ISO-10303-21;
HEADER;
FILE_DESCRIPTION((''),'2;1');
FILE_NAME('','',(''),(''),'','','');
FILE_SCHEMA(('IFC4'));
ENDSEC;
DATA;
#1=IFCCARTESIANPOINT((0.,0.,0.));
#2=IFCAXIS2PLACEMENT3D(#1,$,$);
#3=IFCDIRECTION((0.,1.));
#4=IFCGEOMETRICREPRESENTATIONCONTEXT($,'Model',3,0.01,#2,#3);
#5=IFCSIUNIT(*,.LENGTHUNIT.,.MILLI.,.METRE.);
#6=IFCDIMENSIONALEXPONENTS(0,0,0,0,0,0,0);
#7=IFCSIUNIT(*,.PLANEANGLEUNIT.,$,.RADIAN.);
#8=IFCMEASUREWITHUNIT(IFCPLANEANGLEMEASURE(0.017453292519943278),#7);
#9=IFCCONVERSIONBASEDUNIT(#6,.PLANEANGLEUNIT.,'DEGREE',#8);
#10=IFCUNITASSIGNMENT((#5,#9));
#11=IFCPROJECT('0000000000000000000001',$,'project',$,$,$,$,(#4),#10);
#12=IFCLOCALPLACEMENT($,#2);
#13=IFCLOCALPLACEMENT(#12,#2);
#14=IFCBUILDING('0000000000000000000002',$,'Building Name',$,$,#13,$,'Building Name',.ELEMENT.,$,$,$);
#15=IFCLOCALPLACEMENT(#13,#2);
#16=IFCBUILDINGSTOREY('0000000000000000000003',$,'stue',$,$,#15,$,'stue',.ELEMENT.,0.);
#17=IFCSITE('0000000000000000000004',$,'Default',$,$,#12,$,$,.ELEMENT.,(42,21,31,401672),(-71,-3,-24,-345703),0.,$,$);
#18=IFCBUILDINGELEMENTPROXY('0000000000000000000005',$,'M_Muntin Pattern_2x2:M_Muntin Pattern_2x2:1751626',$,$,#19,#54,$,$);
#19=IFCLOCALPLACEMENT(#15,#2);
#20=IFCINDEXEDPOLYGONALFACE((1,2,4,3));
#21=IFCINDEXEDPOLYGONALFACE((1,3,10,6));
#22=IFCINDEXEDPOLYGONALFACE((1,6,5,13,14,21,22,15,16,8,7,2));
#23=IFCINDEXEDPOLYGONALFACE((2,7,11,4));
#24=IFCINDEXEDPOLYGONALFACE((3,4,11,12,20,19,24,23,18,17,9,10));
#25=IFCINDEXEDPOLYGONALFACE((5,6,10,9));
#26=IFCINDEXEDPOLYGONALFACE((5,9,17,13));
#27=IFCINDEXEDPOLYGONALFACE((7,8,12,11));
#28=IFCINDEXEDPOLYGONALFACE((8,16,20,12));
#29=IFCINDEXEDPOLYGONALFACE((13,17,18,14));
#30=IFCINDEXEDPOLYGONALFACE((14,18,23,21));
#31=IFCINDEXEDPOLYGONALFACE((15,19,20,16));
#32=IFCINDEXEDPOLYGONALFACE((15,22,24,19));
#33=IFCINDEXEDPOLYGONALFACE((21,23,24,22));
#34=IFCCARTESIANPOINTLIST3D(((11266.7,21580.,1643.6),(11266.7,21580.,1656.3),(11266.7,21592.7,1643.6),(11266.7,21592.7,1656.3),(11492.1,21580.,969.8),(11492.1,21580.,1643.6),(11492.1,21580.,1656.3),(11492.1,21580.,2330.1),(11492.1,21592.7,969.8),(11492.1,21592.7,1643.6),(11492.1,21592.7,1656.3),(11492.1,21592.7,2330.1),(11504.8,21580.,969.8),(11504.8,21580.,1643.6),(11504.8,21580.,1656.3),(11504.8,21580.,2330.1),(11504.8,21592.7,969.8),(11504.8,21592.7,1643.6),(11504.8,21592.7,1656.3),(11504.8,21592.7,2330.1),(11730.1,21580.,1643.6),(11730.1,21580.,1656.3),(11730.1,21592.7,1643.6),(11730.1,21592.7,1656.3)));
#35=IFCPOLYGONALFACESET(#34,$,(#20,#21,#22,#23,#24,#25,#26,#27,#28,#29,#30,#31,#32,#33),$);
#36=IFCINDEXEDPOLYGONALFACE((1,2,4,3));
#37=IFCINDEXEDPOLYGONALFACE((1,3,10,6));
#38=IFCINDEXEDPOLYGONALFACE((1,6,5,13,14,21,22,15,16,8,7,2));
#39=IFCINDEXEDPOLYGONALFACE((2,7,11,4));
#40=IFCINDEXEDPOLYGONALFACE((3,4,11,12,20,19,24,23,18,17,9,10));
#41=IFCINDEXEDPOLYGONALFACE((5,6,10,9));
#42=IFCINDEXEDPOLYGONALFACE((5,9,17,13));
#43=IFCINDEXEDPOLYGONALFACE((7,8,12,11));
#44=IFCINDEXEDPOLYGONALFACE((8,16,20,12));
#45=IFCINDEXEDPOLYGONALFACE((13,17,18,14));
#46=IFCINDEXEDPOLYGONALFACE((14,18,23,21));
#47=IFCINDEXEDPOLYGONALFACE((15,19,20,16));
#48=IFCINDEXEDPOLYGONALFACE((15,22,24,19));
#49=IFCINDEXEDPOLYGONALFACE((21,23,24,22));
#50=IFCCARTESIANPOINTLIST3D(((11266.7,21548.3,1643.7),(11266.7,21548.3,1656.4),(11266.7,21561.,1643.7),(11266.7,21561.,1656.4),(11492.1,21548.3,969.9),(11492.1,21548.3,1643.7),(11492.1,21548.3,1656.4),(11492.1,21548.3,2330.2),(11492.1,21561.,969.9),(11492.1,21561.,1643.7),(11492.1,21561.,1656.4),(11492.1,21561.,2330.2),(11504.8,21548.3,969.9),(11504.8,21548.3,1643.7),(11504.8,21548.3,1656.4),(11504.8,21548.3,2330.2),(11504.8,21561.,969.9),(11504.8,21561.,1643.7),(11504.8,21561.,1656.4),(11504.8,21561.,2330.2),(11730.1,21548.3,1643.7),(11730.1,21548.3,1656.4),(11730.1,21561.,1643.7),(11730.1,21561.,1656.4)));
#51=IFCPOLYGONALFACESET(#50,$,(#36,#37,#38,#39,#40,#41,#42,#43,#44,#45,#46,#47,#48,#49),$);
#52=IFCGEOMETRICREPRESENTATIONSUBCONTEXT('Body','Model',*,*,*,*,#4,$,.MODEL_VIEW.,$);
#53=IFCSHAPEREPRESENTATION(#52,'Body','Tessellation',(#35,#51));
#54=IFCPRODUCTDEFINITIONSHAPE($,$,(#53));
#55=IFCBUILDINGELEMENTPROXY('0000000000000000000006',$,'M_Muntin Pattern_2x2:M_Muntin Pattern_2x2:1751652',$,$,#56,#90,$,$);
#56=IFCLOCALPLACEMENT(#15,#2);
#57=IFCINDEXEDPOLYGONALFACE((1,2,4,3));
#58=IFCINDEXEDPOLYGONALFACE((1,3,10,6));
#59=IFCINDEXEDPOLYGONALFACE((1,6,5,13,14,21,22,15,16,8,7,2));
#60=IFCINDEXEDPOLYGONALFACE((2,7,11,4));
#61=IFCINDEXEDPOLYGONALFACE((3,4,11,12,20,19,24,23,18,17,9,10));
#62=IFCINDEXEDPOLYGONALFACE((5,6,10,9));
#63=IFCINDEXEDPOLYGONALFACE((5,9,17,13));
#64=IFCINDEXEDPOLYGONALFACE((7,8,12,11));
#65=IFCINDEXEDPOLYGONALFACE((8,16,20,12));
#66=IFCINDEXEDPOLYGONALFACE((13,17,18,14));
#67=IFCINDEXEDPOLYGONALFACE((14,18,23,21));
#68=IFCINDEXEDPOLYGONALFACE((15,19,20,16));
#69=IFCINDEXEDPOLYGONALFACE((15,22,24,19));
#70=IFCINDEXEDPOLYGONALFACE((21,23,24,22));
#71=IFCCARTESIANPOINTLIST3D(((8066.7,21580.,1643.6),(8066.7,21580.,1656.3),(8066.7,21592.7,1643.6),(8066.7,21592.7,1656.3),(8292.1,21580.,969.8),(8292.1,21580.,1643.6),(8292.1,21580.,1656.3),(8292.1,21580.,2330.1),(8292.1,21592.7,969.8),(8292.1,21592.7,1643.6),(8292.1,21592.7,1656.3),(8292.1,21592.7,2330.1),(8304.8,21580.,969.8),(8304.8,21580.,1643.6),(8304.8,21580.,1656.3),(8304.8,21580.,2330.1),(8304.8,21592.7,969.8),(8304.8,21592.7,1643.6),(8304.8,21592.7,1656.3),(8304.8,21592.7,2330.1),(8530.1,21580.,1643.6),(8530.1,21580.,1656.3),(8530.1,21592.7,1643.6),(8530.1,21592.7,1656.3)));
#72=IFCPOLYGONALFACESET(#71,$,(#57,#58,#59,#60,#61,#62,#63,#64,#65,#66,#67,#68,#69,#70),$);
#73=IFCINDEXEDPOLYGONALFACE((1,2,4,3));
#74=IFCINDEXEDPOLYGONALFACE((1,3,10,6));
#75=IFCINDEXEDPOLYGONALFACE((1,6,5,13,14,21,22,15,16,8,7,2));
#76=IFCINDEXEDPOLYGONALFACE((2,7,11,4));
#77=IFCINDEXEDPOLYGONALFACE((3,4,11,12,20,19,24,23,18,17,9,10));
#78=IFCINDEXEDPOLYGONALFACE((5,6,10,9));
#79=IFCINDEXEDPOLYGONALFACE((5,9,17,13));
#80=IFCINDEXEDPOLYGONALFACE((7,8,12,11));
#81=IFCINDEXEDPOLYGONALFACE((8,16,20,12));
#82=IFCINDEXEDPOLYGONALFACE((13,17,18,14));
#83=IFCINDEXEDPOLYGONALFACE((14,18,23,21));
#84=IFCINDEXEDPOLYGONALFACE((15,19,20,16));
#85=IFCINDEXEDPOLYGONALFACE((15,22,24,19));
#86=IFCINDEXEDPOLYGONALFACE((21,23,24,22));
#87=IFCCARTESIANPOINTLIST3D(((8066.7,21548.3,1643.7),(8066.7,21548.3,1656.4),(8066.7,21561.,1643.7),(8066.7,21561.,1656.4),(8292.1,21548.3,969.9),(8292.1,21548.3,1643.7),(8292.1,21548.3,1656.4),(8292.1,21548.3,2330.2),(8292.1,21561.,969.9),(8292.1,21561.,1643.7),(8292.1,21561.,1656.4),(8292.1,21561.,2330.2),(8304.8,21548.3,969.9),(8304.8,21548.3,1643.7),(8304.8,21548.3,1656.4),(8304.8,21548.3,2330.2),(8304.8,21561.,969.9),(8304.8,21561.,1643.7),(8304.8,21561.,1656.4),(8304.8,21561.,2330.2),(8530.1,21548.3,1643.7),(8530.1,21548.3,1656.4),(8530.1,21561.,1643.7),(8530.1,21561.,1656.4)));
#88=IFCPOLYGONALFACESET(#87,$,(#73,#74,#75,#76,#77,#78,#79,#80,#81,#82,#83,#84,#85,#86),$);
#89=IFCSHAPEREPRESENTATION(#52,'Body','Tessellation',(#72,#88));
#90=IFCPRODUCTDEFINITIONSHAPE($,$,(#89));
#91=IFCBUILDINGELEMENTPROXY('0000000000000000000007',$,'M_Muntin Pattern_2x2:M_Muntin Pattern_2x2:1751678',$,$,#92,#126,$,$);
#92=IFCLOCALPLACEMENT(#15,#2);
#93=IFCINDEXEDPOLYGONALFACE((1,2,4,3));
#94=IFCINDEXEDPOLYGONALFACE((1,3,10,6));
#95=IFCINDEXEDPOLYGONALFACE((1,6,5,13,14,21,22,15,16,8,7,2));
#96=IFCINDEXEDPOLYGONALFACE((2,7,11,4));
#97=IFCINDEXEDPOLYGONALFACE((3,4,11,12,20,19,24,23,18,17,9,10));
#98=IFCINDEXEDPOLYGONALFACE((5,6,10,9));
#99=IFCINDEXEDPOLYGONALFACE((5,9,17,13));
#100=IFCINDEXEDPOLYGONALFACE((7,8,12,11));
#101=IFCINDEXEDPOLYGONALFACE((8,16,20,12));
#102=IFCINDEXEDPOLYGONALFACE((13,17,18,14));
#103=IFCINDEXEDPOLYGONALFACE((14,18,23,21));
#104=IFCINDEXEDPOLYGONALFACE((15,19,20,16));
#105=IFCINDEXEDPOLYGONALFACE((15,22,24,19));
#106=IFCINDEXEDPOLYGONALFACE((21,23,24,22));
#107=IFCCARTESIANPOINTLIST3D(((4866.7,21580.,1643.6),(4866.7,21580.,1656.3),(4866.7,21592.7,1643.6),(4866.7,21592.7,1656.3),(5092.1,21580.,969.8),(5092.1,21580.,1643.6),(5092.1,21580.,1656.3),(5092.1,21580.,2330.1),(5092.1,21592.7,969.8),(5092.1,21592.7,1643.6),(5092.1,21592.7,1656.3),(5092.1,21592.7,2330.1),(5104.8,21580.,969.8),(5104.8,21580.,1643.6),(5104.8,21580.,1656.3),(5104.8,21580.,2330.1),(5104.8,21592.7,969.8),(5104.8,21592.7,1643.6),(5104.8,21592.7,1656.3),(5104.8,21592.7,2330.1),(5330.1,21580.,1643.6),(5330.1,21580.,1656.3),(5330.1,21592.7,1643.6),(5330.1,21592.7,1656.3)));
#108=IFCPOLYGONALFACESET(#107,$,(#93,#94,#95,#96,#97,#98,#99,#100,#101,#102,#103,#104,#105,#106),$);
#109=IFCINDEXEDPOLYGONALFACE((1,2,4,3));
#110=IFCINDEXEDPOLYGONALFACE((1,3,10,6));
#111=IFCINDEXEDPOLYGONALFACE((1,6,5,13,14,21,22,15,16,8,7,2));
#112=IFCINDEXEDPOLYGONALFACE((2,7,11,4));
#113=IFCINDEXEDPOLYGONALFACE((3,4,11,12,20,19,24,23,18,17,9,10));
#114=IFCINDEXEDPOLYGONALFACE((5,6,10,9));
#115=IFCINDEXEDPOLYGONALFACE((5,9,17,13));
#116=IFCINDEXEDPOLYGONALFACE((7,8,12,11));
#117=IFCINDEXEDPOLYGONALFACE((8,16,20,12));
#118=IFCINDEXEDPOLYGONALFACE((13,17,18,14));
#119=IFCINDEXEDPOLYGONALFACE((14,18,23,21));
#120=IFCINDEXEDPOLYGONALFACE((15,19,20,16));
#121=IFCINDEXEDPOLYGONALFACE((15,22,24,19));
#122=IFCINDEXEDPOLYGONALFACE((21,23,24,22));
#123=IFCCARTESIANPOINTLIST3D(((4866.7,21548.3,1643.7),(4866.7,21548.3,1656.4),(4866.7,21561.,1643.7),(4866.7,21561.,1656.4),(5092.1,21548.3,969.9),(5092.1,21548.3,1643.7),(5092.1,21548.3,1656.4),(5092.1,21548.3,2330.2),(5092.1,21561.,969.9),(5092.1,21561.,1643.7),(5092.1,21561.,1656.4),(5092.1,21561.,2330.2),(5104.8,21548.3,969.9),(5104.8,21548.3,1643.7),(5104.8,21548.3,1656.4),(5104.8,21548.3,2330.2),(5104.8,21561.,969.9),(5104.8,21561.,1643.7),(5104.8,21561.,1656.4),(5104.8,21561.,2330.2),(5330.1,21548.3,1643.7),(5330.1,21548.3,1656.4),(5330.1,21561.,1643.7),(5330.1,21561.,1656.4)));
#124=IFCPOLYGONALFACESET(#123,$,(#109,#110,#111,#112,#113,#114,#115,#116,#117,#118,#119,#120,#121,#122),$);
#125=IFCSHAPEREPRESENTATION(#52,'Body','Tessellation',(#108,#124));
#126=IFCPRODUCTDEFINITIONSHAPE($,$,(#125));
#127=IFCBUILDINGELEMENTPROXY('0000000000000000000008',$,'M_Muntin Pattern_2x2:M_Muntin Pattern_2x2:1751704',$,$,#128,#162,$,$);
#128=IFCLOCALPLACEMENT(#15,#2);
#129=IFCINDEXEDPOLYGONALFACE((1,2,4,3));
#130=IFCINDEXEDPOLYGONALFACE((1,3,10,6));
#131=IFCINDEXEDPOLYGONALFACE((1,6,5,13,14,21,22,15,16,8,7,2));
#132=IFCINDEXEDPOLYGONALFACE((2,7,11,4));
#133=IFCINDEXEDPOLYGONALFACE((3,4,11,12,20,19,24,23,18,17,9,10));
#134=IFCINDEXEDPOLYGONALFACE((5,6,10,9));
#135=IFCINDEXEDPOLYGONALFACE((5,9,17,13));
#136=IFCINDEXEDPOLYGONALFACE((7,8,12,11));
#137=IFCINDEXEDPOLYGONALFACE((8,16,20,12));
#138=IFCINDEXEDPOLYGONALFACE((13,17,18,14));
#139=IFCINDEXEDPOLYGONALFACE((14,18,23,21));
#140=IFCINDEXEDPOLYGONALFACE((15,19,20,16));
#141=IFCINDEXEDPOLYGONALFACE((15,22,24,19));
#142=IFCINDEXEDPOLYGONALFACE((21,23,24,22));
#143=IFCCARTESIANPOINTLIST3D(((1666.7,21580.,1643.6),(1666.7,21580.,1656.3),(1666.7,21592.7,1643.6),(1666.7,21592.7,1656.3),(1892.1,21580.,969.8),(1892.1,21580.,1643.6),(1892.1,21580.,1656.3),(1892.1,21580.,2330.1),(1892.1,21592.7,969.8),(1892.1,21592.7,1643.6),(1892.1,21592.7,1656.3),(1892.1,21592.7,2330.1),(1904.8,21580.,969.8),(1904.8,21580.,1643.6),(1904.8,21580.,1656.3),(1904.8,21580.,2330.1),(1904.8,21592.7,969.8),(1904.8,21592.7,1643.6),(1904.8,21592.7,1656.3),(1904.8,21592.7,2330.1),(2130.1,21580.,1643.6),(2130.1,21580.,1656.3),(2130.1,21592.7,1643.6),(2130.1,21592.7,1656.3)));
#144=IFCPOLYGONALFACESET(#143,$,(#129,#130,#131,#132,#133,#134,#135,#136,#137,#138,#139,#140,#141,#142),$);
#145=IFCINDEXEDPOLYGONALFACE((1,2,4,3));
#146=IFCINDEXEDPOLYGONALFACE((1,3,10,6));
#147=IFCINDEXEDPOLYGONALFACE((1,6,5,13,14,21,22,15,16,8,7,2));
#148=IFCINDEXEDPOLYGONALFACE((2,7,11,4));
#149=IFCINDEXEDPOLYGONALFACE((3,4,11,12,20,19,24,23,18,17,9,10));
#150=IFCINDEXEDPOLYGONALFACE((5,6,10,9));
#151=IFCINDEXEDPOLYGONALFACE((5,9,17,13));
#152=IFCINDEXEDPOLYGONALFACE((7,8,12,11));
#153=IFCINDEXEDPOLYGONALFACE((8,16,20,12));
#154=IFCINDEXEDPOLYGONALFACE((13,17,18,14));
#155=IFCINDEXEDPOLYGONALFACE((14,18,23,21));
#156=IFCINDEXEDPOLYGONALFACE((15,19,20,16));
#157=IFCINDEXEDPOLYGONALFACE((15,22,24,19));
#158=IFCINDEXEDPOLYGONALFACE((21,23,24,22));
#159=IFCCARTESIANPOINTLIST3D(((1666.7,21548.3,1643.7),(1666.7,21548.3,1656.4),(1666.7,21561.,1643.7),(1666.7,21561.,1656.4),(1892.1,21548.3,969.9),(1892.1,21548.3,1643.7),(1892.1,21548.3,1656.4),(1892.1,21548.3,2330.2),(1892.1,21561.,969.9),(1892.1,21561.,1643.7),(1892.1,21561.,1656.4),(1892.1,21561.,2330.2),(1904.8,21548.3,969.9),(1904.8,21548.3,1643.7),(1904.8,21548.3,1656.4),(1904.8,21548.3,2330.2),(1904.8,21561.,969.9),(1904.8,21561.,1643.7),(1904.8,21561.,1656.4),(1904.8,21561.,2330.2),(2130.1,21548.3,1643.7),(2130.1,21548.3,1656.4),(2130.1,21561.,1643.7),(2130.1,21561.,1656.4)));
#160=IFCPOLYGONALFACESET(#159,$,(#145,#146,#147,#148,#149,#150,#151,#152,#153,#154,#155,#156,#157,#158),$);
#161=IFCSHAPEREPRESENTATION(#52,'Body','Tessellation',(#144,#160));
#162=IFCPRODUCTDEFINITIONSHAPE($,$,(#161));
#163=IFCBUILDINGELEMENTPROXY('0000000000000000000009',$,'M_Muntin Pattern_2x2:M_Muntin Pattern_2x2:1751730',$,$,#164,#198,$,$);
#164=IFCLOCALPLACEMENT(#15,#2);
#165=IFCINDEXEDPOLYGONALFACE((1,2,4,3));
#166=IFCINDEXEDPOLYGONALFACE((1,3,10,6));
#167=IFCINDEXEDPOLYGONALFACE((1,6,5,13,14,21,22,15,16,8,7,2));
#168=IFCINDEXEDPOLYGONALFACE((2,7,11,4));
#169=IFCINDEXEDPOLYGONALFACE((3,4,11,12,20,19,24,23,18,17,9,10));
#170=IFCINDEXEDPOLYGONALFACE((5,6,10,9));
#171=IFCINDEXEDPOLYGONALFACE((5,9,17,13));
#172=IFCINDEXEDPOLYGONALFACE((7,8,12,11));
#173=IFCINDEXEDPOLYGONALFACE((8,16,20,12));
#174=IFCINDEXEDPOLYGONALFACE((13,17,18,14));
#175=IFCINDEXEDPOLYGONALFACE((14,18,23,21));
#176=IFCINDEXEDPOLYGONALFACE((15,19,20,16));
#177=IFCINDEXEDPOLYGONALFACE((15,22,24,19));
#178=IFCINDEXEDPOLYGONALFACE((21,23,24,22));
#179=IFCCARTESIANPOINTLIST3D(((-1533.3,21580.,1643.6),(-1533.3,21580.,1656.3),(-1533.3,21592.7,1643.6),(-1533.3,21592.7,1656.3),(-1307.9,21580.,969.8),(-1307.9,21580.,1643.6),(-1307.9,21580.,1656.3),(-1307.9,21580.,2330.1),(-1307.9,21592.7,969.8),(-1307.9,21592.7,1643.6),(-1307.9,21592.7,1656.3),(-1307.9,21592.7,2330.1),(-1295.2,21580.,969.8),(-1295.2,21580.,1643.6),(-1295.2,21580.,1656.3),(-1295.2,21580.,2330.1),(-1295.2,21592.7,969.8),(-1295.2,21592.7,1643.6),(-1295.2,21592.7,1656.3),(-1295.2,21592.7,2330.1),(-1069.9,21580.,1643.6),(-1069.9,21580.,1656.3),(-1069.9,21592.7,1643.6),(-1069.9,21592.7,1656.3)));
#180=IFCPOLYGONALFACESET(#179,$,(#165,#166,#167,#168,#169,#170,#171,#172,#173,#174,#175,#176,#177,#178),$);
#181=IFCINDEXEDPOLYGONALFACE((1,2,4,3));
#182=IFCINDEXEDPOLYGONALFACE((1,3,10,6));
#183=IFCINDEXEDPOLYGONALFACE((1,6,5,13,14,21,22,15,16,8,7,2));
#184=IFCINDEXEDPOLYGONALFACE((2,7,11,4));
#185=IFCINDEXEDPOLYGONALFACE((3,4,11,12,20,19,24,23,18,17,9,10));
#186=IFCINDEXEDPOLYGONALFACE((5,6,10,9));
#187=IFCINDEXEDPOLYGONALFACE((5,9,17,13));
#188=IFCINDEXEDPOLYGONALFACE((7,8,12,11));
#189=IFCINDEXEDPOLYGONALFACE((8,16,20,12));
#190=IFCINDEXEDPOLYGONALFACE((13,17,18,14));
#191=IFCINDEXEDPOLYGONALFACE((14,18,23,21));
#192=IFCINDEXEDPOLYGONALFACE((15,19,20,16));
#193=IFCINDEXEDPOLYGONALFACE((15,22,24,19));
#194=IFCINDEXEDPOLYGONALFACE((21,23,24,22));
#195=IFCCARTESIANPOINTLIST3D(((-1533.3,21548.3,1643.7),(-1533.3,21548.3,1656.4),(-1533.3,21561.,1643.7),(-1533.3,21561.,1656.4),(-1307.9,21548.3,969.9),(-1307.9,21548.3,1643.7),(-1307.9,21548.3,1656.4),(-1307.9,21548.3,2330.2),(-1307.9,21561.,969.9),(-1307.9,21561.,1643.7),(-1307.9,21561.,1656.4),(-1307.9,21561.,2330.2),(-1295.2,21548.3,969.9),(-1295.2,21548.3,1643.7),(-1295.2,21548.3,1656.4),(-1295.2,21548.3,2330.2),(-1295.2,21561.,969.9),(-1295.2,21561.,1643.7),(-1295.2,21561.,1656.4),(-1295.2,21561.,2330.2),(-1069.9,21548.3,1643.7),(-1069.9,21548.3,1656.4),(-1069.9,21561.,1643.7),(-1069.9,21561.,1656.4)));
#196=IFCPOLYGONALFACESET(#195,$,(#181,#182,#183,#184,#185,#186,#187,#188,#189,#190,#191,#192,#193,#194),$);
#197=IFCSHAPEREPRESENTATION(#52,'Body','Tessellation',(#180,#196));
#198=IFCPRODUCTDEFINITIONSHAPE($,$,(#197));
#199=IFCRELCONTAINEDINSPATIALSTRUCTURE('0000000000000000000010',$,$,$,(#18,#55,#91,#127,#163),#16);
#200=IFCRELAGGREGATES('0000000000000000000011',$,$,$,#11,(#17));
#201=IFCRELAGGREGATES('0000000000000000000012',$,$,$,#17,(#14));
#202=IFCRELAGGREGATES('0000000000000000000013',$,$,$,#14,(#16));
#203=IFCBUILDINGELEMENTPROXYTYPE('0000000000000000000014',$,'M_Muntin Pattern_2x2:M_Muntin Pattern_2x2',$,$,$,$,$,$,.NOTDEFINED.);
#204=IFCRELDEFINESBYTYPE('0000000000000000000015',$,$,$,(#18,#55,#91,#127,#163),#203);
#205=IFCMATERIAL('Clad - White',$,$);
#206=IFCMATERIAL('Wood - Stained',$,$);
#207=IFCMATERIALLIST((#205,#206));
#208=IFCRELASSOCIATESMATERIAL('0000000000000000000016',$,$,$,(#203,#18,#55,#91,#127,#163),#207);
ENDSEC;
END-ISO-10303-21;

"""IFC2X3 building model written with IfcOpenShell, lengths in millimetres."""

from ifc_helpers import new_model, entity, si_unit, converted_unit, direction, frame, origin, place, context, subcontext, project, spatial, polyline, outline, extrude, source, transform, mapped, material, material_list, type_object, type_shapes, element, save


model = new_model("IFC2X3")

# Units and contexts
model_context = context("Model", 3, precision=0.01, world=origin(), true_north=direction((0.0, 1.0)))
body_context = subcontext(model_context, "Body", "Model", "MODEL_VIEW")
ifc_project = project(units=[si_unit("LENGTHUNIT", "METRE", prefix="MILLI"), converted_unit("PLANEANGLEUNIT", "DEGREE", entity("IfcPlaneAngleMeasure", 0.017453292519943278), si_unit("PLANEANGLEUNIT", "RADIAN"), dimensions=[0, 0, 0, 0, 0, 0, 0])], contexts=[model_context])

# Site, building, storey
site_placement = place(None, origin())
site = spatial("IfcSite", under=ifc_project, at=site_placement, Name="Default", CompositionType="ELEMENT", RefLatitude=(42, 21, 31, 401672), RefLongitude=(-71, -3, -24, -345703), RefElevation=0.0)
building_placement = place(site_placement, origin())
building = spatial("IfcBuilding", under=site, at=building_placement, Name="Building Name", LongName="Building Name", CompositionType="ELEMENT")
storey_placement = place(building_placement, origin())
storey = spatial("IfcBuildingStorey", under=building, at=storey_placement, Name="stue", LongName="stue", CompositionType="ELEMENT", Elevation=0.0)

# Building element proxies
ifc_material_1 = material(Name="Clad - White")
ifc_material_2 = material(Name="Wood - Stained")
ifc_material_list = material_list([ifc_material_1, ifc_material_2])
building_element_proxy_type_1 = type_object("IfcBuildingElementProxyType", Name="M_Muntin Pattern_2x2:M_Muntin Pattern_2x2", PredefinedType="NOTDEFINED", material=ifc_material_list)
shared_shape_1 = source(origin(), body_context, "Body", "SweptSolid", [
    extrude(outline(polyline([(6.4, -6.4), (680.1, -6.4), (680.1, 6.3), (6.4, 6.3), (6.4, 231.7), (-6.3, 231.7), (-6.3, 6.3), (-680.2, 6.3), (-680.2, -6.4), (-6.3, -6.4), (-6.3, -231.7), (6.4, -231.7), (6.4, -6.4)])), frame((0.0, -22.2, 680.1), z_axis=(0.0, 1.0, 0.0), x_axis=(0.0, 0.0, 1.0)), (0.0, 0.0, 1.0), 12.7),
    extrude(outline(polyline([(6.4, -6.4), (680.2, -6.4), (680.2, 6.3), (6.4, 6.3), (6.4, 231.7), (-6.3, 231.7), (-6.3, 6.3), (-680.2, 6.3), (-680.2, -6.4), (-6.3, -6.4), (-6.3, -231.7), (6.4, -231.7), (6.4, -6.4)])), frame((0.0, 9.5, 680.2), z_axis=(0.0, 1.0, 0.0), x_axis=(0.0, 0.0, 1.0)), (0.0, 0.0, 1.0), 12.7),
])
type_shapes(building_element_proxy_type_1, [shared_shape_1])
for number, where, z_axis, x_axis, name in (
    (1, (11498.4, 21570.5, 969.9), (0.0, 0.0, 1.0), (-1.0, 0.0, 0.0), "M_Muntin Pattern_2x2:M_Muntin Pattern_2x2:1751626"),
    (2, (8298.4, 21570.5, 969.9), (0.0, 0.0, 1.0), (-1.0, 0.0, 0.0), "M_Muntin Pattern_2x2:M_Muntin Pattern_2x2:1751652"),
    (3, (5098.4, 21570.5, 969.9), (0.0, 0.0, 1.0), (-1.0, 0.0, 0.0), "M_Muntin Pattern_2x2:M_Muntin Pattern_2x2:1751678"),
    (4, (1898.4, 21570.5, 969.9), (0.0, 0.0, 1.0), (-1.0, 0.0, 0.0), "M_Muntin Pattern_2x2:M_Muntin Pattern_2x2:1751704"),
    (5, (-1301.6, 21570.5, 969.9), (0.0, 0.0, 1.0), (-1.0, 0.0, 0.0), "M_Muntin Pattern_2x2:M_Muntin Pattern_2x2:1751730"),
):
    element("IfcBuildingElementProxy", number, at=place(storey_placement, frame(where, z_axis=z_axis, x_axis=x_axis)), inside=storey, type_object=building_element_proxy_type_1, material=ifc_material_list, Name=name, context=body_context, shape_type="MappedRepresentation", body=[
        mapped(shared_shape_1, transform((0.0, 0.0, 0.0), scale=1.0)),
    ])

save(model, "model.ifc")
